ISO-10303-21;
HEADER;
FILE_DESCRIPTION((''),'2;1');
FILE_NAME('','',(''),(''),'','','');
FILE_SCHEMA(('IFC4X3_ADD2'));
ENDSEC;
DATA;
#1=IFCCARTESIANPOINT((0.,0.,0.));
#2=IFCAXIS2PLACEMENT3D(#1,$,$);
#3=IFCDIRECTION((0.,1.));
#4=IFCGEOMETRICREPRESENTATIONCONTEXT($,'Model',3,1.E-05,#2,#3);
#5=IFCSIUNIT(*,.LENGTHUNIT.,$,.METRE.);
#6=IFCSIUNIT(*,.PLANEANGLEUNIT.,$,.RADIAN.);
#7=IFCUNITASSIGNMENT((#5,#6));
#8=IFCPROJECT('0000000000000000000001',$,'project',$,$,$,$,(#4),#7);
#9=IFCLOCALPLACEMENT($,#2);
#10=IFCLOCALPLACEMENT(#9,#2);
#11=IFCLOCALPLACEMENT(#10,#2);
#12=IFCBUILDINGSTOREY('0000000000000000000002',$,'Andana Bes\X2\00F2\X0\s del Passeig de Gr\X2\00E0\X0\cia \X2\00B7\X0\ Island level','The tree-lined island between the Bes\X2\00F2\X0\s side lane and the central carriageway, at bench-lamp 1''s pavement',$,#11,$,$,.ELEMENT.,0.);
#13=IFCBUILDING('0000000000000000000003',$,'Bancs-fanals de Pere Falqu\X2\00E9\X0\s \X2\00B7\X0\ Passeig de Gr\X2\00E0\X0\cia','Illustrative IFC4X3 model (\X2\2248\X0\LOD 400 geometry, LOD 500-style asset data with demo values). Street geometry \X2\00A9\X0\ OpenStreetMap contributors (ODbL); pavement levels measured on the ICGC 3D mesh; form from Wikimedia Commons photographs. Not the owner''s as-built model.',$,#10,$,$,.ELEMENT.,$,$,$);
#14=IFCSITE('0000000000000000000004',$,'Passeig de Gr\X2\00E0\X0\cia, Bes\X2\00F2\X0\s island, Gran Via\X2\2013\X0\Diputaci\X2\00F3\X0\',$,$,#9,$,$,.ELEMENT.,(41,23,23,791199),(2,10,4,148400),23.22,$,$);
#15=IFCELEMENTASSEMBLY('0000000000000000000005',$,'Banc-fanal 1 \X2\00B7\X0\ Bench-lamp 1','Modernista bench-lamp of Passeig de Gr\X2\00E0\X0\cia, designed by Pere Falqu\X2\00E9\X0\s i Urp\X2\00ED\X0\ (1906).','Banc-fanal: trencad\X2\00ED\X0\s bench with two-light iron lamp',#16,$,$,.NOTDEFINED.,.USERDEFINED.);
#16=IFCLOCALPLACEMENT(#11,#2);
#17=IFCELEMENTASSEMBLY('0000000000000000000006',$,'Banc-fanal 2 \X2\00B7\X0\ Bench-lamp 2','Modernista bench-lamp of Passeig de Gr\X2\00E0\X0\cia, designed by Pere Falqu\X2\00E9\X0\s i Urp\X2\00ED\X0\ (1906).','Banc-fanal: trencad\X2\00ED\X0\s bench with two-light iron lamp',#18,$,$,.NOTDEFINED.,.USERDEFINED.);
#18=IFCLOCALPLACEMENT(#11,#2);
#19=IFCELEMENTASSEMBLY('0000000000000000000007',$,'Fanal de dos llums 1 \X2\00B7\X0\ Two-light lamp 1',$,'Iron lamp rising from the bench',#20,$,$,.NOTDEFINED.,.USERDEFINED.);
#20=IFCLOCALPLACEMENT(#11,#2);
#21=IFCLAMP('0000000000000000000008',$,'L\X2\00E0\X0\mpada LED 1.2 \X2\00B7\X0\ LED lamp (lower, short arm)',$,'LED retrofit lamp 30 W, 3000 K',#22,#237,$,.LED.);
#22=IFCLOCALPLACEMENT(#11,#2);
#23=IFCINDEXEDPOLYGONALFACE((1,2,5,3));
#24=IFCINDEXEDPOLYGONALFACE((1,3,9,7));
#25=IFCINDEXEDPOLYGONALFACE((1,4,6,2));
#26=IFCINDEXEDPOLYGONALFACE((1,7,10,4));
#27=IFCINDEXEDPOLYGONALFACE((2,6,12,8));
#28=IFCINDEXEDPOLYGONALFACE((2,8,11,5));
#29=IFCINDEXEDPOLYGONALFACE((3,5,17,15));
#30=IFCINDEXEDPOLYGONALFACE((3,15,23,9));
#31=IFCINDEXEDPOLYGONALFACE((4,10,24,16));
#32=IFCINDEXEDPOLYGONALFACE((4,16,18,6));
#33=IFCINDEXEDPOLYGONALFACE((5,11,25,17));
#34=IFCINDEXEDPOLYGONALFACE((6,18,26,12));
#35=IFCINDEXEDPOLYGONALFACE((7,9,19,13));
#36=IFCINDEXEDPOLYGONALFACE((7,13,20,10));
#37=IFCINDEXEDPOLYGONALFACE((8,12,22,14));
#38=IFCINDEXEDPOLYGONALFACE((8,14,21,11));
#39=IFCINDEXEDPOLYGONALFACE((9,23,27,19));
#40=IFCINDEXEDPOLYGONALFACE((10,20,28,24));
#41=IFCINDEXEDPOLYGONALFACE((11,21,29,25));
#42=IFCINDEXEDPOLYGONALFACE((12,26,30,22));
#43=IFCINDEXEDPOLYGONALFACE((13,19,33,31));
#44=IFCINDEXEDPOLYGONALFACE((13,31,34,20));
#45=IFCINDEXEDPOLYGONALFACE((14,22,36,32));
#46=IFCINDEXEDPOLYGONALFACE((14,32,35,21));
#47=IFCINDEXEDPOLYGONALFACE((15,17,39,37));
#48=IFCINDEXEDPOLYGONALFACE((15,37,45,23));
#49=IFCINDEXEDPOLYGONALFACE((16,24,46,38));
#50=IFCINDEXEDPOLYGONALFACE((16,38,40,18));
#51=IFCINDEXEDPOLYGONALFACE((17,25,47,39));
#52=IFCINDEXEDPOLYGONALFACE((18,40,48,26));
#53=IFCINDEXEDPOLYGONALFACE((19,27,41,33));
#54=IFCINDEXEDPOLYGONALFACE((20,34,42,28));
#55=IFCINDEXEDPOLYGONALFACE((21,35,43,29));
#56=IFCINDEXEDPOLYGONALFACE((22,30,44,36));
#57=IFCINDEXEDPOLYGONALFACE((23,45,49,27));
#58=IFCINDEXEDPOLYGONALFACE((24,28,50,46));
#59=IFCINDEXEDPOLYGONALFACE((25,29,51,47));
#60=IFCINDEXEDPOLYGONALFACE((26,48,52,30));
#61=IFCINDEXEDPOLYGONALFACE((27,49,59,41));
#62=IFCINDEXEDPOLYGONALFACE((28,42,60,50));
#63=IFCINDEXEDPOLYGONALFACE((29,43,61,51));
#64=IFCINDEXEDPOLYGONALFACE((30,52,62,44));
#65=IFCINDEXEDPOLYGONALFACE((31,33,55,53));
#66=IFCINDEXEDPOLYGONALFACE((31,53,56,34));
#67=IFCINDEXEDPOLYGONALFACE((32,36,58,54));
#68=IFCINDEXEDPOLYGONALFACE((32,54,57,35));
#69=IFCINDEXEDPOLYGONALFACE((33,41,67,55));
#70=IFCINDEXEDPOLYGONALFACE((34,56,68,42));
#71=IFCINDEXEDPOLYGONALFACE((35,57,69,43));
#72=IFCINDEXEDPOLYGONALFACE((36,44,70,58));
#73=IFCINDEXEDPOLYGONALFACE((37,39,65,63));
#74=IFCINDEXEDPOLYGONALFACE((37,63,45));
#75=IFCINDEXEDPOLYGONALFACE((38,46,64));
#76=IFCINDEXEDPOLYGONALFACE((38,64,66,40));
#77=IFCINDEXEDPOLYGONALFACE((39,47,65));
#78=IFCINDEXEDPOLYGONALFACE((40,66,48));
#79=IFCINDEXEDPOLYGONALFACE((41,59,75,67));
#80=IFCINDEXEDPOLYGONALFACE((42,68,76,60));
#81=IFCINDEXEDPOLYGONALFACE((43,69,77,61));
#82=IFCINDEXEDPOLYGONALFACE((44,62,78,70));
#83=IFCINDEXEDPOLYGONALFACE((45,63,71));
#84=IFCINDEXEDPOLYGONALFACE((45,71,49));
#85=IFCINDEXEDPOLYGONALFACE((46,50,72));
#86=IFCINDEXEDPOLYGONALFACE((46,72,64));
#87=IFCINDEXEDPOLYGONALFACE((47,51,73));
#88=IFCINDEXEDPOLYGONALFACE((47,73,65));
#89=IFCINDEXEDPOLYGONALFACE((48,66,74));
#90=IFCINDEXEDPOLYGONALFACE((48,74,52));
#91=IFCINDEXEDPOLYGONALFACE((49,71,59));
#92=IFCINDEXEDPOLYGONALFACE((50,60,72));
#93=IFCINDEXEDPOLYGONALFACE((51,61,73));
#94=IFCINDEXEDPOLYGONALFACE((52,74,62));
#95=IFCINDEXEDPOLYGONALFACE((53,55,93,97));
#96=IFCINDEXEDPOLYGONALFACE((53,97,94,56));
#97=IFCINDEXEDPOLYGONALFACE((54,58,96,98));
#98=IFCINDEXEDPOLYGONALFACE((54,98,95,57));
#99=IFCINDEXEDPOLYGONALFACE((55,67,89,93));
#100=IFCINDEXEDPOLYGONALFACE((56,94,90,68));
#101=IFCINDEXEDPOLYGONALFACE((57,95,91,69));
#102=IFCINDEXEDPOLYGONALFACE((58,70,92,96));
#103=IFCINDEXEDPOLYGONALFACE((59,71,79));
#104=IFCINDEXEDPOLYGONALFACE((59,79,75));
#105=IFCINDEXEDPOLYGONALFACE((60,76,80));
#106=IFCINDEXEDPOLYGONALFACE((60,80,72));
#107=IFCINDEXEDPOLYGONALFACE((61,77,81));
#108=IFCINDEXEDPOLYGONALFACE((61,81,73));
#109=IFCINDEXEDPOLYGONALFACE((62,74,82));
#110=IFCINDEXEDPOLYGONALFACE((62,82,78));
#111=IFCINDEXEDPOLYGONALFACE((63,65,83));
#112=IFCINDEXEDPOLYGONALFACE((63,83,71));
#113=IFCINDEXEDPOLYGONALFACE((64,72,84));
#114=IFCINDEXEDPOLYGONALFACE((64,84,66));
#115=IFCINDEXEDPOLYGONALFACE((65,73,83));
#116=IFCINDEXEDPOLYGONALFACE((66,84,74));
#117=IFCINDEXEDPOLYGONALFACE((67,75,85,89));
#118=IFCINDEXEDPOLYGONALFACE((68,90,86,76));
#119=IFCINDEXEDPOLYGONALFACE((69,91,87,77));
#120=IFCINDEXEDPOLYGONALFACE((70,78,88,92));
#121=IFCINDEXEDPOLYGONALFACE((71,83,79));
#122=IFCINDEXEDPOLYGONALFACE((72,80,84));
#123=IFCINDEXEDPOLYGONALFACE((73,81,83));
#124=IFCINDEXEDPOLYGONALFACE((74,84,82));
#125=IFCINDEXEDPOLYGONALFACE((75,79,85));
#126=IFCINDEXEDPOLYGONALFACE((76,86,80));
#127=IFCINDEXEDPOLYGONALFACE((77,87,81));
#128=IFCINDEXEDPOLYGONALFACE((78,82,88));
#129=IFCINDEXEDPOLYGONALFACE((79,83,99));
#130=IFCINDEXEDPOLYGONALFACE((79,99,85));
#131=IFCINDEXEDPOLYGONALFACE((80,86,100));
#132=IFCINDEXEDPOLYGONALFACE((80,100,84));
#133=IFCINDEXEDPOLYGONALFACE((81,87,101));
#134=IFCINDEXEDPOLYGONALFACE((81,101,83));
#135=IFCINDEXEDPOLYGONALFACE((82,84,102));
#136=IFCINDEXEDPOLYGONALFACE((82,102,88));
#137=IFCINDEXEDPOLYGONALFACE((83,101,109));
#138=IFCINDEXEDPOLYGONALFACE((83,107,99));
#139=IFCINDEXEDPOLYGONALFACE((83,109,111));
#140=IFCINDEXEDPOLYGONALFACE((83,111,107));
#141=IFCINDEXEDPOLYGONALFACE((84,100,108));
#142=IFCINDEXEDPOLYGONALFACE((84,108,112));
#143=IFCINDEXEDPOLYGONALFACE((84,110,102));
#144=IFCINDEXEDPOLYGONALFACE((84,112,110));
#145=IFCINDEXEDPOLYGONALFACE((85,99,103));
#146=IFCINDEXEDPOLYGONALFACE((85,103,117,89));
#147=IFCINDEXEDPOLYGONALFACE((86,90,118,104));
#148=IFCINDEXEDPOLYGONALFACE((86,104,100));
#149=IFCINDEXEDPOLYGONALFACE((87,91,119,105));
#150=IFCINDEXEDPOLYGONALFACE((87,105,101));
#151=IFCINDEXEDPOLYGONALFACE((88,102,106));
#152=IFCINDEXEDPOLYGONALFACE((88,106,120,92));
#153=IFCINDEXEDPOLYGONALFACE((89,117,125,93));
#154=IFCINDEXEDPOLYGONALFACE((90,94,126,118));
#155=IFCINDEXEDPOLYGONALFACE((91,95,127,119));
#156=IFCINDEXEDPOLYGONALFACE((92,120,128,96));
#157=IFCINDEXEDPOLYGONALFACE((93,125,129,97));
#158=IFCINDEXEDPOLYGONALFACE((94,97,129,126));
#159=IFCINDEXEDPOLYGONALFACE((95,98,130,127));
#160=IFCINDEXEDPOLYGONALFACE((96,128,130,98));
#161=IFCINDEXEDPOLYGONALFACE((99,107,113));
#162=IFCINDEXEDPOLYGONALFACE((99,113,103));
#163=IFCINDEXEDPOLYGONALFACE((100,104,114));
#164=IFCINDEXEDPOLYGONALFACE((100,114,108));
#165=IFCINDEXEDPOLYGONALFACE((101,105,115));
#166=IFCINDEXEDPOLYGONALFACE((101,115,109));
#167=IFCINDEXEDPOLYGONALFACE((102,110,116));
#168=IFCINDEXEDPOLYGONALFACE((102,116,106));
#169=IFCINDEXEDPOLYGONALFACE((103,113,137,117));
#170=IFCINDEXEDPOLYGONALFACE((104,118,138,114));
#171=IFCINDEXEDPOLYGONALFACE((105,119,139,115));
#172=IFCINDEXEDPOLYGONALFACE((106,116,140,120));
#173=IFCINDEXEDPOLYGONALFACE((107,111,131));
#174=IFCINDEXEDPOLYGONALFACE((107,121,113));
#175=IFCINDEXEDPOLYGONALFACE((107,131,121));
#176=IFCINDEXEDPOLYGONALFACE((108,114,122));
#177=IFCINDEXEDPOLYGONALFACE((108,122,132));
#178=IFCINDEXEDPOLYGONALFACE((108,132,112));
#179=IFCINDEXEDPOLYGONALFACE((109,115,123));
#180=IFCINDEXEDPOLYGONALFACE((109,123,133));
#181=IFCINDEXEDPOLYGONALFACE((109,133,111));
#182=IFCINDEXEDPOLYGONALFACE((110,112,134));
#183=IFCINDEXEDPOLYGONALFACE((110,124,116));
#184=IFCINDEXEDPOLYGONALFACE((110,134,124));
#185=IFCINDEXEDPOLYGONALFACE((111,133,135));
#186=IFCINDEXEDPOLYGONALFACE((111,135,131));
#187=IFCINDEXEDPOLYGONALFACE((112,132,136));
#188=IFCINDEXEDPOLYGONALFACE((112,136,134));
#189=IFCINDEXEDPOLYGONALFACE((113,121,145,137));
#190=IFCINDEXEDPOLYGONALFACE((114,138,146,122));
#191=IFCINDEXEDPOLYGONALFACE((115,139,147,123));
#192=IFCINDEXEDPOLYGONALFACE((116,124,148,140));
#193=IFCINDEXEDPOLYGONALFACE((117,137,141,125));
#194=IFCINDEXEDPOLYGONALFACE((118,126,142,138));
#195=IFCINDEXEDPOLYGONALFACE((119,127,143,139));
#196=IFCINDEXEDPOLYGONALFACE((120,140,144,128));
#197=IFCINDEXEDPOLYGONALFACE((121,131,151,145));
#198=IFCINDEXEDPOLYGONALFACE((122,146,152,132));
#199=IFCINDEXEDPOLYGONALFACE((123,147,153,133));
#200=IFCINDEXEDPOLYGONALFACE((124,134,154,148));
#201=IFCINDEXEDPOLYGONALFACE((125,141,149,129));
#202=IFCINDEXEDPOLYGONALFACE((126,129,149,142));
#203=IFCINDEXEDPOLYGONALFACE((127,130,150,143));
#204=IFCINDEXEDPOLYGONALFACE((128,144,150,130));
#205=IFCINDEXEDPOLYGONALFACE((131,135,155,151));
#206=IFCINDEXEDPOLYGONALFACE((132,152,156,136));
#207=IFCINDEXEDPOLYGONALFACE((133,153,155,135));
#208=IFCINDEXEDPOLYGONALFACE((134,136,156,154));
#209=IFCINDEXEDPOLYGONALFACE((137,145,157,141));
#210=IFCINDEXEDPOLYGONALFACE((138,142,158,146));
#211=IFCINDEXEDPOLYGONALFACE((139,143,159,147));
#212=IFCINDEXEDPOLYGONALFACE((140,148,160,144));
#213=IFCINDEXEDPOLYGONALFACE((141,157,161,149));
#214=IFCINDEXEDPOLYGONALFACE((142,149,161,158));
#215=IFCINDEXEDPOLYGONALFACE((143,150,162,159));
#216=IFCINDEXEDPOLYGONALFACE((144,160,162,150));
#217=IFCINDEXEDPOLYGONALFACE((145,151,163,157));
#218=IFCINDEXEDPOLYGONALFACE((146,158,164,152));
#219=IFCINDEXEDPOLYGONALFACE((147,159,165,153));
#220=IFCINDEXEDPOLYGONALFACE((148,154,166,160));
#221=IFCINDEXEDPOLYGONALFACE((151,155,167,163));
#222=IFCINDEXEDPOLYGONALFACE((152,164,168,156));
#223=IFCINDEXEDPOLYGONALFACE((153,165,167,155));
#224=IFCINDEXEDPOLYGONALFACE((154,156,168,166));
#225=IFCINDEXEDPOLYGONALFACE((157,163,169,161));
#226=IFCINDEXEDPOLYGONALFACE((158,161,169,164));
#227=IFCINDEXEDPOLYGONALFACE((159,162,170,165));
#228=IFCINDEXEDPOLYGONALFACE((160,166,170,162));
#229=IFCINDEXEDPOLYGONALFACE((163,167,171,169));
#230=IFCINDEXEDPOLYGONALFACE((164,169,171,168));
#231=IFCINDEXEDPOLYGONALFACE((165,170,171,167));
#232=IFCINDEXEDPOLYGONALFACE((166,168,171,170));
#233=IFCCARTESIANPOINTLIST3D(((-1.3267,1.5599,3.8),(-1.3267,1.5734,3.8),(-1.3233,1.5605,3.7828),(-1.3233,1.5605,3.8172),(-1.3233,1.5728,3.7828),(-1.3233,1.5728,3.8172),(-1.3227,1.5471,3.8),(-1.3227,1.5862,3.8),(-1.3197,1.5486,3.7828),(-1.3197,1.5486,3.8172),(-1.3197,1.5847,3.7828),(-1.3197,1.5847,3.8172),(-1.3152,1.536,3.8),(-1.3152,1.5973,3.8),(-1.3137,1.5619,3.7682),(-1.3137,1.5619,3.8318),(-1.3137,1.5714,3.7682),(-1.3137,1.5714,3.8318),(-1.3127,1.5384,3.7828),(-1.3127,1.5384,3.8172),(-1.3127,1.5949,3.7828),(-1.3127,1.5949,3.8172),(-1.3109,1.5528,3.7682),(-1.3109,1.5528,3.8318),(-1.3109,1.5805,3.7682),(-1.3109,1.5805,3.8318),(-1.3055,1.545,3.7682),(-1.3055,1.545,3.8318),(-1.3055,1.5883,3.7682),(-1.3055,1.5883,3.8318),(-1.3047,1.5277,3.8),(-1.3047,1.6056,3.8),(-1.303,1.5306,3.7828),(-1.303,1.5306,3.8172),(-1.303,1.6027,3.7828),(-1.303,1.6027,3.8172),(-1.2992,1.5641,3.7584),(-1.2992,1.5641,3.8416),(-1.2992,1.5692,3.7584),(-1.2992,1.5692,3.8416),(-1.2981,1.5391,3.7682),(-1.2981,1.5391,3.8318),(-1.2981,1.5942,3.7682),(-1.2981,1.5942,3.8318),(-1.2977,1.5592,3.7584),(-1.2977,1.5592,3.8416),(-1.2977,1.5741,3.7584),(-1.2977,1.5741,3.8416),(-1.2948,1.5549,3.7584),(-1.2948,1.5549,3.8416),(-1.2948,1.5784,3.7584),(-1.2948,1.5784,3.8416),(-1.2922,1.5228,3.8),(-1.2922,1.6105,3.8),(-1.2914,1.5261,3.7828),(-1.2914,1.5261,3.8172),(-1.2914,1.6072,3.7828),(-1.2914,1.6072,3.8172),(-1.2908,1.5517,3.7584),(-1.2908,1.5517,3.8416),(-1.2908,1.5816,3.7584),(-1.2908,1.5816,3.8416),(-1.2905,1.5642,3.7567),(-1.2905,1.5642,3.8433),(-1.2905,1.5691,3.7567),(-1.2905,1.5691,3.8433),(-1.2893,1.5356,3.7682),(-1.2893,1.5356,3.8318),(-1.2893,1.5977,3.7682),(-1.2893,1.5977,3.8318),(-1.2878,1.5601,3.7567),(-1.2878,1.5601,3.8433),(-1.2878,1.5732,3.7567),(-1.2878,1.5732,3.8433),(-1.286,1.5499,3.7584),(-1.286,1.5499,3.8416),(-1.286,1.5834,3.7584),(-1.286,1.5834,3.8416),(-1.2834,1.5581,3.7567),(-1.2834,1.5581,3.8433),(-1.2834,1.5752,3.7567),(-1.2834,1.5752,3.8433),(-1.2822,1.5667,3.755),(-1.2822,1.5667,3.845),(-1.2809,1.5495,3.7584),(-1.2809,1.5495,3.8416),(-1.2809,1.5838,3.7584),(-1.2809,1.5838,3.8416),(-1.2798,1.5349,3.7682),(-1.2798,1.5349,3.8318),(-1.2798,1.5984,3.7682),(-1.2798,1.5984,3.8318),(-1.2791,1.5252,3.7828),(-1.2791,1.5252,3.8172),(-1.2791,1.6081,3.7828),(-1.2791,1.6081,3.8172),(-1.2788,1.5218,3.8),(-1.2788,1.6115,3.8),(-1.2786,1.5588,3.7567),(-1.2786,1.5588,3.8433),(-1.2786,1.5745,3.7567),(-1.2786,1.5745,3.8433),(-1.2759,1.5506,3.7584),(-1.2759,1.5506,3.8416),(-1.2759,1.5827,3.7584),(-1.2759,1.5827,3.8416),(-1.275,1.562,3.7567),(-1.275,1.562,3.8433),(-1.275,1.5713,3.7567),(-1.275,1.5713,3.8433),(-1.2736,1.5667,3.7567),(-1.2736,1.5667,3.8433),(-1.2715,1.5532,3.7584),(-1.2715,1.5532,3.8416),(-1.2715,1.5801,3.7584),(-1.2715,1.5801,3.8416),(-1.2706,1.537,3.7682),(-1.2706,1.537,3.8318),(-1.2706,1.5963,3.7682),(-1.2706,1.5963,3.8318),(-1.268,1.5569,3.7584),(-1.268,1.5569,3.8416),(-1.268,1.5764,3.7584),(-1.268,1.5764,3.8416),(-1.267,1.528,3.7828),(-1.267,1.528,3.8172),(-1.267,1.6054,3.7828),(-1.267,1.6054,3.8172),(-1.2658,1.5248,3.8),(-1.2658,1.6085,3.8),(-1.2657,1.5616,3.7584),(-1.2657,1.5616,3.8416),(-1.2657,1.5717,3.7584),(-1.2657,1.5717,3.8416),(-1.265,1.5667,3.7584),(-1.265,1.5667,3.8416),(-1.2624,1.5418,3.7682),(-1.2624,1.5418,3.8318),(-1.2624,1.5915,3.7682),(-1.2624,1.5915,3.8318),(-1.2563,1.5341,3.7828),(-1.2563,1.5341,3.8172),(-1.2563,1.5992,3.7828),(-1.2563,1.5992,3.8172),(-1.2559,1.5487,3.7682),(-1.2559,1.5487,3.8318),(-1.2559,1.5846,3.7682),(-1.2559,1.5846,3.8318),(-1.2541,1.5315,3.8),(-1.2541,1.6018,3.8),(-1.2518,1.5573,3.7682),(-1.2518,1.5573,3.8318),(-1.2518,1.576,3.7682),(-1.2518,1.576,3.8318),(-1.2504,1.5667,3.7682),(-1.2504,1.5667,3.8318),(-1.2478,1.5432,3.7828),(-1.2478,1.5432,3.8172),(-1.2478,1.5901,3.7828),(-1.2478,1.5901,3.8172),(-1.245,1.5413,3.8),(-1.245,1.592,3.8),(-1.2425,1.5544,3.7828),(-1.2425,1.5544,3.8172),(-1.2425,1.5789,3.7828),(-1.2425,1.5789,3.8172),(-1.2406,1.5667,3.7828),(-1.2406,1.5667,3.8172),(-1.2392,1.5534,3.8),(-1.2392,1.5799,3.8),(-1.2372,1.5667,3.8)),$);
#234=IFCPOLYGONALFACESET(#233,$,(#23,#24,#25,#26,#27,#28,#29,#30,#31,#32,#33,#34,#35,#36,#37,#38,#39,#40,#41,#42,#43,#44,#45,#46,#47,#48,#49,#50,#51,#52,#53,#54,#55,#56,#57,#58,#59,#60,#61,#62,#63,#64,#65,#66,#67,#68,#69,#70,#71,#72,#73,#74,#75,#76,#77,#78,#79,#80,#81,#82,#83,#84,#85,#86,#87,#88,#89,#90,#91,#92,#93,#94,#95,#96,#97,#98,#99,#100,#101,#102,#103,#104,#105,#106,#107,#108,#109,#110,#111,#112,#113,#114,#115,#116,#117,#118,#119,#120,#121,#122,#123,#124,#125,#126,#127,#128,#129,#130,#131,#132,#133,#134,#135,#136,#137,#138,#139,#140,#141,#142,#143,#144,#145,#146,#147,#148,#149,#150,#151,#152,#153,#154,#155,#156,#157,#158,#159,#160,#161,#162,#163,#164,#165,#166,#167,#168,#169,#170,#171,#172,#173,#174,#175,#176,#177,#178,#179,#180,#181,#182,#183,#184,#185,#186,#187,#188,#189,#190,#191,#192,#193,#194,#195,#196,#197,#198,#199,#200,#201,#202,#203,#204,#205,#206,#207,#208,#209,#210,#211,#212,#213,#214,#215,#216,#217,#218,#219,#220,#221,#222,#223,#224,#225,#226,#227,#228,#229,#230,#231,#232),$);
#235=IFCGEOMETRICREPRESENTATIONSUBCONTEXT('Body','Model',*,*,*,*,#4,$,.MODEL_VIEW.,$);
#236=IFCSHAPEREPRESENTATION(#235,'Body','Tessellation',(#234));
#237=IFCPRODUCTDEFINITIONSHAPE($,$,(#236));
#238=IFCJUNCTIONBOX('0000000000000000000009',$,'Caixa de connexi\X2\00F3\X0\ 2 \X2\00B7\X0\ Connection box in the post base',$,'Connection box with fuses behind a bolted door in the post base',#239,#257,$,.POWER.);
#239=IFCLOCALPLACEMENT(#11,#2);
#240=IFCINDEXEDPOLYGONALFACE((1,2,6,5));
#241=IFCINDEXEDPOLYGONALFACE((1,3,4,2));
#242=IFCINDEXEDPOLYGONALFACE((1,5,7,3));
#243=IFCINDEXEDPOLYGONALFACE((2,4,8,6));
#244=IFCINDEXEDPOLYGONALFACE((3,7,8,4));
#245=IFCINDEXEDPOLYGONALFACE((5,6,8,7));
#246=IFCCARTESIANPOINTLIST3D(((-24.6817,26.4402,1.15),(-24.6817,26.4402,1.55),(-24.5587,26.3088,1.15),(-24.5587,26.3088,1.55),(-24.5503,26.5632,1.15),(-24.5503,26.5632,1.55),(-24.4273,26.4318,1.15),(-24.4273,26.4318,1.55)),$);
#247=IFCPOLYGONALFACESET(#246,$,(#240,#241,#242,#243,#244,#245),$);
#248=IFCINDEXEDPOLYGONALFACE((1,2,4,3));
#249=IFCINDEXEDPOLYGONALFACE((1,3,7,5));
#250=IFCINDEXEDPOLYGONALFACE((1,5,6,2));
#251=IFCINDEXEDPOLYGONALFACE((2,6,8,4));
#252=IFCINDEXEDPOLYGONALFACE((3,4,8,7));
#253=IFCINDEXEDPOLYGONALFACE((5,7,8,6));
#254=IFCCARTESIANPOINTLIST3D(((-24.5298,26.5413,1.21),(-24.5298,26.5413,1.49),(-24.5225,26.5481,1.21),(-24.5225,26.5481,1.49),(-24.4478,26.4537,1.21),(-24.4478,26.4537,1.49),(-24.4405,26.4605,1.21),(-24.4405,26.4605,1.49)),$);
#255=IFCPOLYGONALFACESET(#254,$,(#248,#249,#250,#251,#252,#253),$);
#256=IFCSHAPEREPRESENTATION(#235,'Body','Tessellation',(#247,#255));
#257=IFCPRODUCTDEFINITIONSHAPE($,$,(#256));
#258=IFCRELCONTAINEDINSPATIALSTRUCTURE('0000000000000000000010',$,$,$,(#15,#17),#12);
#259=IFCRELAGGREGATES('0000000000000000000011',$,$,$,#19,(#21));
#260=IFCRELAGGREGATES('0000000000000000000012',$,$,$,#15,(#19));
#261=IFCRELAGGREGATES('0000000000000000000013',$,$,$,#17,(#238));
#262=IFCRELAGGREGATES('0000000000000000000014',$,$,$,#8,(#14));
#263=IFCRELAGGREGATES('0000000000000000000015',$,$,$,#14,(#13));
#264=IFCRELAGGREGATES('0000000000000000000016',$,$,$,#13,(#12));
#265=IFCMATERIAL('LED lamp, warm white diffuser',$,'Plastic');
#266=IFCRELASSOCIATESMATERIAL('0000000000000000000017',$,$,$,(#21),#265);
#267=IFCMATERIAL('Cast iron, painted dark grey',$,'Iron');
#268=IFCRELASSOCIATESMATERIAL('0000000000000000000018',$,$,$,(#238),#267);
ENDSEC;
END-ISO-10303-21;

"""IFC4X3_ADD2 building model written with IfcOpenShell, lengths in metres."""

from ifc_helpers import new_model, entity, si_unit, direction, frame, frame_2d, origin, place, context, subcontext, project, spatial, rectangle, extrude, material, element, aggregate, save


model = new_model("IFC4X3_ADD2")

# Units and contexts
model_context = context("Model", 3, precision=1e-05, world=origin(), true_north=direction((0.0, 1.0)))
body_context = subcontext(model_context, "Body", "Model", "MODEL_VIEW")
ifc_project = project(units=[si_unit("LENGTHUNIT", "METRE"), si_unit("PLANEANGLEUNIT", "RADIAN")], contexts=[model_context])

# Site, building, storey
site_placement = place(None, origin())
site = spatial("IfcSite", under=ifc_project, at=site_placement, Name="Passeig de Gràcia, Besòs island, Gran Via–Diputació", CompositionType="ELEMENT", RefLatitude=(41, 23, 23, 791199), RefLongitude=(2, 10, 4, 148400), RefElevation=23.22)
building_placement = place(site_placement, origin())
building = spatial("IfcBuilding", under=site, at=building_placement, Name="Bancs-fanals de Pere Falqués · Passeig de Gràcia", Description="Illustrative IFC4X3 model (≈LOD 400 geometry, LOD 500-style asset data with demo values). Street geometry © OpenStreetMap contributors (ODbL); pavement levels measured on the ICGC 3D mesh; form from Wikimedia Commons photographs. Not the owner's as-built model.", CompositionType="ELEMENT")
storey_placement = place(building_placement, origin())
storey = spatial("IfcBuildingStorey", under=building, at=storey_placement, Name="Andana Besòs del Passeig de Gràcia · Island level", Description="The tree-lined island between the Besòs side lane and the central carriageway, at bench-lamp 1's pavement", CompositionType="ELEMENT", Elevation=0.0)

# Element assemblies
assembly_1_placement = place(building_placement, origin())
assembly_1 = element("IfcElementAssembly", 1, at=assembly_1_placement, inside=storey, Name="Banc-fanal 1 · Bench-lamp 1", Description="Modernista bench-lamp of Passeig de Gràcia, designed by Pere Falqués i Urpí (1906).", ObjectType="Banc-fanal: trencadís bench with two-light iron lamp", AssemblyPlace="NOTDEFINED", PredefinedType="USERDEFINED")
assembly_2_placement = place(building_placement, origin())
assembly_2 = element("IfcElementAssembly", 2, at=assembly_2_placement, inside=storey, Name="Banc-fanal 2 · Bench-lamp 2", Description="Modernista bench-lamp of Passeig de Gràcia, designed by Pere Falqués i Urpí (1906).", ObjectType="Banc-fanal: trencadís bench with two-light iron lamp", AssemblyPlace="NOTDEFINED", PredefinedType="USERDEFINED")

# Element assembly
assembly_3_placement = place(building_placement, origin())
assembly_3 = element("IfcElementAssembly", 3, at=assembly_3_placement, Name="Fanal de dos llums 1 · Two-light lamp 1", ObjectType="Iron lamp rising from the bench", AssemblyPlace="NOTDEFINED", PredefinedType="USERDEFINED")

# Shared definitions
ifc_material_1 = material(Name="Cast iron, painted dark grey", Category="Iron")

# Shared definitions
ifc_material_2 = material(Name="LED lamp, warm white diffuser", Category="Plastic")

# Lamp
lamp_1_placement = place(building_placement, origin())
lamp_1 = element("IfcLamp", 4, at=lamp_1_placement, material=ifc_material_2, Name="Làmpada LED 1.2 · LED lamp (lower, short arm)", ObjectType="LED retrofit lamp 30 W, 3000 K", PredefinedType="LED", context=body_context, shape_type="SweptSolid", body=[
    entity("IfcRevolvedAreaSolid", entity("IfcArbitraryClosedProfileDef", "AREA", None, entity("IfcPolyline", [entity("IfcCartesianPoint", [0.0, -0.045]), entity("IfcCartesianPoint", [0.0172, -0.0416]), entity("IfcCartesianPoint", [0.0318, -0.0318]), entity("IfcCartesianPoint", [0.0416, -0.0172]), entity("IfcCartesianPoint", [0.045, 0.0]), entity("IfcCartesianPoint", [0.0416, 0.0172]), entity("IfcCartesianPoint", [0.0318, 0.0318]), entity("IfcCartesianPoint", [0.0172, 0.0416]), entity("IfcCartesianPoint", [0.0, 0.045]), entity("IfcCartesianPoint", [0.0, -0.045])])), entity("IfcAxis2Placement3D", entity("IfcCartesianPoint", [-1.2822, 1.5667, 3.8]), entity("IfcDirection", [0.0, -1.0, 0.0]), entity("IfcDirection", [1.0, 0.0, 0.0])), entity("IfcAxis1Placement", entity("IfcCartesianPoint", [0.0, 0.0, 0.0]), entity("IfcDirection", [0.0, 1.0, 0.0])), 6.283185),
])
aggregate(assembly_3, [lamp_1])

# Junction box
junction_box_1_placement = place(building_placement, origin())
junction_box_1 = element("IfcJunctionBox", 5, at=junction_box_1_placement, material=ifc_material_1, Name="Caixa de connexió 2 · Connection box in the post base", ObjectType="Connection box with fuses behind a bolted door in the post base", PredefinedType="POWER", context=body_context, shape_type="SweptSolid", body=[
    extrude(rectangle(XDim=0.18, YDim=0.18, at=frame_2d((0.0, 0.0), x_axis=(-0.683274, 0.730162))), frame((-24.5545, 26.436, 1.15)), (0.0, 0.0, 1.0), 0.4),
    extrude(rectangle(XDim=0.12, YDim=0.01, at=frame_2d((0.0, 0.0), x_axis=(-0.683274, 0.730162))), frame((-24.4851, 26.5009, 1.21)), (0.0, 0.0, 1.0), 0.28),
])

aggregate(assembly_1, [assembly_3])
aggregate(assembly_2, [junction_box_1])

save(model, "model.ifc")
